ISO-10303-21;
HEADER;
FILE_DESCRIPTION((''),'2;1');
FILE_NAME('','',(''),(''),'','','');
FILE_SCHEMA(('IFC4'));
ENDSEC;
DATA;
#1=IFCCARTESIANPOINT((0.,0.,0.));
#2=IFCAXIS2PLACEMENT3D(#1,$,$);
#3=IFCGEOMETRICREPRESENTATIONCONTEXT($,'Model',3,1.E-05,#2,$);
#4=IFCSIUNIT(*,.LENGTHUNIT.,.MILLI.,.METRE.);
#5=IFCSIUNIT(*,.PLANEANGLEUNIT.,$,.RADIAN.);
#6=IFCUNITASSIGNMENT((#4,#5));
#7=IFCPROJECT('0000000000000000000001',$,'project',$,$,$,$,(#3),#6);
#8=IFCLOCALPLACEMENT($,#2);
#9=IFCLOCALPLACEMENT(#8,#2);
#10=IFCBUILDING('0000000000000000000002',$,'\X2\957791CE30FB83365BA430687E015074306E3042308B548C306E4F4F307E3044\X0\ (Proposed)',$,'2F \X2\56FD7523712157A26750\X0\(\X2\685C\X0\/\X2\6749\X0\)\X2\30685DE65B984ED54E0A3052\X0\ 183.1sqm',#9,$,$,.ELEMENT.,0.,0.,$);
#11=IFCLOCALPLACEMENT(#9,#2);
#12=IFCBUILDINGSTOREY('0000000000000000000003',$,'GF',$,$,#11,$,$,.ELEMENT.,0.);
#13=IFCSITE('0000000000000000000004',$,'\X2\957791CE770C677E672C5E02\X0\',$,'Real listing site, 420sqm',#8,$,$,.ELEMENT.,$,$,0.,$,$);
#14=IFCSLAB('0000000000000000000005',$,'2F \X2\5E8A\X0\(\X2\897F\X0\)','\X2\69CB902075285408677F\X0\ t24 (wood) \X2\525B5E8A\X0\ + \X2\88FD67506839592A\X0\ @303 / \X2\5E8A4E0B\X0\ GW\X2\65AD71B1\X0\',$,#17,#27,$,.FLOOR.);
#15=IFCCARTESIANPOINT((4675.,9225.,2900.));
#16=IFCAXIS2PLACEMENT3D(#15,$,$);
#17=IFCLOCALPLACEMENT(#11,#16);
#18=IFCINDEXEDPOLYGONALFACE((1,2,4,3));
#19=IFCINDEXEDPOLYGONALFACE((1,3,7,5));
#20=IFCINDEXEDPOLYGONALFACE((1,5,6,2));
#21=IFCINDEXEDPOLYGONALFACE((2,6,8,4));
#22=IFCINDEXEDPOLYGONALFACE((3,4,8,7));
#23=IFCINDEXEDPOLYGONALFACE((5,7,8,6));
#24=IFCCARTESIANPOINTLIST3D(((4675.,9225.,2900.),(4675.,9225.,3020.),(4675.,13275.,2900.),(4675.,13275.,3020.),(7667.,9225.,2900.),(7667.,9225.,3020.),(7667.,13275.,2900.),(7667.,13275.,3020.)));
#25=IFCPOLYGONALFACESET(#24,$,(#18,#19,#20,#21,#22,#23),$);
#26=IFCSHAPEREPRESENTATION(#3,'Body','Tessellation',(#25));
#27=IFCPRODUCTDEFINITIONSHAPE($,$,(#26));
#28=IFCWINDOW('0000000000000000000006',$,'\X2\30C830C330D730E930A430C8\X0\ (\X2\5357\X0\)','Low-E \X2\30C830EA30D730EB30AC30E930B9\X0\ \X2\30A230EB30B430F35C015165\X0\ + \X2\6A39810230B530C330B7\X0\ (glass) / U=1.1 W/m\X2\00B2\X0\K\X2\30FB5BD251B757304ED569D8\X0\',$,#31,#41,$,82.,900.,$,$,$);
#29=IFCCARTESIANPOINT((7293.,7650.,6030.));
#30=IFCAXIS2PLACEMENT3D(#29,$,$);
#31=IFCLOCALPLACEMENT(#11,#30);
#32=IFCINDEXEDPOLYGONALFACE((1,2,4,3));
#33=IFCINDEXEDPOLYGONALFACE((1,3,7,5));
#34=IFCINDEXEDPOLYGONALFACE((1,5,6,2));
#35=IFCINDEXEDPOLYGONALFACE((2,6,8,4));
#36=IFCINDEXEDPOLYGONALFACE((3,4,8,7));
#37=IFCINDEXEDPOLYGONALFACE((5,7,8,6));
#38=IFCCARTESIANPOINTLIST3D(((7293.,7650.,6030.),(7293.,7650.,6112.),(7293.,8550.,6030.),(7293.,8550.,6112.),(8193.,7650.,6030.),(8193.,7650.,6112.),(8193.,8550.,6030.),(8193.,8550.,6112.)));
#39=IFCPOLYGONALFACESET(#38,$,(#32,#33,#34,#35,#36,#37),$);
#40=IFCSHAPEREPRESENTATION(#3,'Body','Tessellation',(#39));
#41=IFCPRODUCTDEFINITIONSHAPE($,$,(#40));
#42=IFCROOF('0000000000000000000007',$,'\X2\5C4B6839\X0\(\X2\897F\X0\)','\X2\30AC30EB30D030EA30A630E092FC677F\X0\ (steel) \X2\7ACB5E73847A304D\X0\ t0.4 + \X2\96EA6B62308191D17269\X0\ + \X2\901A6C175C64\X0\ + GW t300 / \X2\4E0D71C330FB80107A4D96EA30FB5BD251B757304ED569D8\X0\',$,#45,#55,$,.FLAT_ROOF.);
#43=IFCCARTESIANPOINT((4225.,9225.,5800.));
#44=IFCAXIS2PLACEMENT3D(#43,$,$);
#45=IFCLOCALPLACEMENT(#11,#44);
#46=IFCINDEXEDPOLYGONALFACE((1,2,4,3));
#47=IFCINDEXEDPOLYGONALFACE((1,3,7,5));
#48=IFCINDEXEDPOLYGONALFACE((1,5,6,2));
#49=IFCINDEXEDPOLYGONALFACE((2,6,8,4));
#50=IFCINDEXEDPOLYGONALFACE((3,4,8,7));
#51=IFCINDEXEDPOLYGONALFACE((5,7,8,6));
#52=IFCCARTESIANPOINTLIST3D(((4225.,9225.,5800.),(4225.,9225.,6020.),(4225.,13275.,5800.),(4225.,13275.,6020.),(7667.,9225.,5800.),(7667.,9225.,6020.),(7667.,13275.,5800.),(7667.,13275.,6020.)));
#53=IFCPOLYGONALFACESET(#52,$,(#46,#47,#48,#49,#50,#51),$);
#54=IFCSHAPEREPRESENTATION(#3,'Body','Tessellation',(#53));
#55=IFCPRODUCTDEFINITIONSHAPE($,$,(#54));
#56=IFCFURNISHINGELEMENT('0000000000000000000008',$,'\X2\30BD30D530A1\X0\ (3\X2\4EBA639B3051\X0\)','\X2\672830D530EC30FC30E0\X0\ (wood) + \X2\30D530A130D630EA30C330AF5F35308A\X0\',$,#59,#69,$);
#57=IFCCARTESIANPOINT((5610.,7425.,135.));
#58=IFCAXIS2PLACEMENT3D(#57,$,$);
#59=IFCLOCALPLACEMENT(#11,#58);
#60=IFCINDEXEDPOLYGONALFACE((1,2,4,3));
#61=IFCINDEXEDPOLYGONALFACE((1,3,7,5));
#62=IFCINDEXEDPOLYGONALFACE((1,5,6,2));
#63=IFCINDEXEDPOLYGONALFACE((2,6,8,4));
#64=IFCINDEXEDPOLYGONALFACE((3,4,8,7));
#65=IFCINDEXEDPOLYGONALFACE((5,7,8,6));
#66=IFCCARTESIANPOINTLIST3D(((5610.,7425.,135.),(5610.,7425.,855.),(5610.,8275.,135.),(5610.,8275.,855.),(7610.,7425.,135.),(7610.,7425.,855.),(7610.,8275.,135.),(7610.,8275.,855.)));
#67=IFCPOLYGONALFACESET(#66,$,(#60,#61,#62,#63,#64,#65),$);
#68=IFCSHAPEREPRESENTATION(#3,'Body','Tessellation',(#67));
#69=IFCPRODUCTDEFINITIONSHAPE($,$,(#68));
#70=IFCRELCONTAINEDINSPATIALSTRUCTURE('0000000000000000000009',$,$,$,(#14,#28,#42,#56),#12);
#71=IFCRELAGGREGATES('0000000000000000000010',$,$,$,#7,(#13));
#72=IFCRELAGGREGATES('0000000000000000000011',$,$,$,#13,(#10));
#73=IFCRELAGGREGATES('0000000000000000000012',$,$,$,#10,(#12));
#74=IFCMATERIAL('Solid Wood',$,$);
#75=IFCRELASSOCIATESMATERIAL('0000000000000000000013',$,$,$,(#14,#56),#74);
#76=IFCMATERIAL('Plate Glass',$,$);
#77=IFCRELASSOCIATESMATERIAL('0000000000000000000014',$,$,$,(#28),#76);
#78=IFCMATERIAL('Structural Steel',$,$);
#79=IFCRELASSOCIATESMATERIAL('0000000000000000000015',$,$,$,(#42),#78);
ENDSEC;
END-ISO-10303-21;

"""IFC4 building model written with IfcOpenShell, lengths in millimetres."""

from ifc_helpers import new_model, si_unit, frame, frame_2d, origin, place, context, project, spatial, rectangle, extrude, material, element, save


model = new_model("IFC4")

# Units and contexts
model_context = context("Model", 3, precision=1e-05, world=origin())
ifc_project = project(units=[si_unit("LENGTHUNIT", "METRE", prefix="MILLI"), si_unit("PLANEANGLEUNIT", "RADIAN")], contexts=[model_context])

# Site, building, storey
site_placement = place(None, origin())
site = spatial("IfcSite", under=ifc_project, at=site_placement, Name="長野県松本市", ObjectType="Real listing site, 420sqm", CompositionType="ELEMENT", RefElevation=0.0)
building_placement = place(site_placement, origin())
building = spatial("IfcBuilding", under=site, at=building_placement, Name="長野・茶室と縁側のある和の住まい (Proposed)", ObjectType="2F 国産無垢材(桜/杉)と左官仕上げ 183.1sqm", CompositionType="ELEMENT", ElevationOfRefHeight=0.0, ElevationOfTerrain=0.0)
storey_placement = place(building_placement, origin())
storey = spatial("IfcBuildingStorey", under=building, at=storey_placement, Name="GF", CompositionType="ELEMENT", Elevation=0.0)

# Shared definitions
ifc_material_1 = material(Name="Solid Wood")

# Slab
slab_1_placement = place(storey_placement, frame((4675.0, 9225.0, 2900.0)))
element("IfcSlab", 1, at=slab_1_placement, inside=storey, material=ifc_material_1, Name="2F 床(西)", Description="構造用合板 t24 (wood) 剛床 + 製材根太 @303 / 床下 GW断熱", PredefinedType="FLOOR", context=model_context, shape_type="SweptSolid", body=[
    extrude(rectangle(XDim=2992.0, YDim=4050.0, at=frame_2d((1496.0, 2025.0))), frame((4675.0, 9225.0, 2900.0)), (0.0, 0.0, 1.0), 120.0),
])

# Window
ifc_material_2 = material(Name="Plate Glass")
window_placement = place(storey_placement, frame((7293.0, 7650.0, 6030.0)))
element("IfcWindow", 2, at=window_placement, inside=storey, material=ifc_material_2, Name="トップライト (南)", Description="Low-E トリプルガラス アルゴン封入 + 樹脂サッシ (glass) / U=1.1 W/m²K・寒冷地仕様", OverallHeight=82.0, OverallWidth=900.0, context=model_context, shape_type="SweptSolid", body=[
    extrude(rectangle(XDim=900.0, YDim=900.0, at=frame_2d((450.0, 450.0))), frame((7293.0, 7650.0, 6030.0)), (0.0, 0.0, 1.0), 82.0),
])

# Roof
ifc_material_3 = material(Name="Structural Steel")
for number, where, name in (
    (3, (4225.0, 9225.0, 5800.0), "屋根(西)"),
):
    element("IfcRoof", number, at=place(storey_placement, frame(where)), inside=storey, material=ifc_material_3, Name=name, Description="ガルバリウム鋼板 (steel) 立平葺き t0.4 + 雪止め金物 + 通気層 + GW t300 / 不燃・耐積雪・寒冷地仕様", PredefinedType="FLAT_ROOF", context=model_context, shape_type="SweptSolid", body=[
        extrude(rectangle(XDim=3442.0, YDim=4050.0, at=frame_2d((1721.0, 2025.0))), frame((4225.0, 9225.0, 5800.0)), (0.0, 0.0, 1.0), 220.0),
    ])

# Furnishing element
furnishing_placement = place(storey_placement, frame((5610.0, 7425.0, 135.0)))
element("IfcFurnishingElement", 4, at=furnishing_placement, inside=storey, material=ifc_material_1, Name="ソファ (3人掛け)", Description="木フレーム (wood) + ファブリック張り", context=model_context, shape_type="SweptSolid", body=[
    extrude(rectangle(XDim=2000.0, YDim=850.0, at=frame_2d((1000.0, 425.0))), frame((5610.0, 7425.0, 135.0)), (0.0, 0.0, 1.0), 720.0),
])

save(model, "model.ifc")
